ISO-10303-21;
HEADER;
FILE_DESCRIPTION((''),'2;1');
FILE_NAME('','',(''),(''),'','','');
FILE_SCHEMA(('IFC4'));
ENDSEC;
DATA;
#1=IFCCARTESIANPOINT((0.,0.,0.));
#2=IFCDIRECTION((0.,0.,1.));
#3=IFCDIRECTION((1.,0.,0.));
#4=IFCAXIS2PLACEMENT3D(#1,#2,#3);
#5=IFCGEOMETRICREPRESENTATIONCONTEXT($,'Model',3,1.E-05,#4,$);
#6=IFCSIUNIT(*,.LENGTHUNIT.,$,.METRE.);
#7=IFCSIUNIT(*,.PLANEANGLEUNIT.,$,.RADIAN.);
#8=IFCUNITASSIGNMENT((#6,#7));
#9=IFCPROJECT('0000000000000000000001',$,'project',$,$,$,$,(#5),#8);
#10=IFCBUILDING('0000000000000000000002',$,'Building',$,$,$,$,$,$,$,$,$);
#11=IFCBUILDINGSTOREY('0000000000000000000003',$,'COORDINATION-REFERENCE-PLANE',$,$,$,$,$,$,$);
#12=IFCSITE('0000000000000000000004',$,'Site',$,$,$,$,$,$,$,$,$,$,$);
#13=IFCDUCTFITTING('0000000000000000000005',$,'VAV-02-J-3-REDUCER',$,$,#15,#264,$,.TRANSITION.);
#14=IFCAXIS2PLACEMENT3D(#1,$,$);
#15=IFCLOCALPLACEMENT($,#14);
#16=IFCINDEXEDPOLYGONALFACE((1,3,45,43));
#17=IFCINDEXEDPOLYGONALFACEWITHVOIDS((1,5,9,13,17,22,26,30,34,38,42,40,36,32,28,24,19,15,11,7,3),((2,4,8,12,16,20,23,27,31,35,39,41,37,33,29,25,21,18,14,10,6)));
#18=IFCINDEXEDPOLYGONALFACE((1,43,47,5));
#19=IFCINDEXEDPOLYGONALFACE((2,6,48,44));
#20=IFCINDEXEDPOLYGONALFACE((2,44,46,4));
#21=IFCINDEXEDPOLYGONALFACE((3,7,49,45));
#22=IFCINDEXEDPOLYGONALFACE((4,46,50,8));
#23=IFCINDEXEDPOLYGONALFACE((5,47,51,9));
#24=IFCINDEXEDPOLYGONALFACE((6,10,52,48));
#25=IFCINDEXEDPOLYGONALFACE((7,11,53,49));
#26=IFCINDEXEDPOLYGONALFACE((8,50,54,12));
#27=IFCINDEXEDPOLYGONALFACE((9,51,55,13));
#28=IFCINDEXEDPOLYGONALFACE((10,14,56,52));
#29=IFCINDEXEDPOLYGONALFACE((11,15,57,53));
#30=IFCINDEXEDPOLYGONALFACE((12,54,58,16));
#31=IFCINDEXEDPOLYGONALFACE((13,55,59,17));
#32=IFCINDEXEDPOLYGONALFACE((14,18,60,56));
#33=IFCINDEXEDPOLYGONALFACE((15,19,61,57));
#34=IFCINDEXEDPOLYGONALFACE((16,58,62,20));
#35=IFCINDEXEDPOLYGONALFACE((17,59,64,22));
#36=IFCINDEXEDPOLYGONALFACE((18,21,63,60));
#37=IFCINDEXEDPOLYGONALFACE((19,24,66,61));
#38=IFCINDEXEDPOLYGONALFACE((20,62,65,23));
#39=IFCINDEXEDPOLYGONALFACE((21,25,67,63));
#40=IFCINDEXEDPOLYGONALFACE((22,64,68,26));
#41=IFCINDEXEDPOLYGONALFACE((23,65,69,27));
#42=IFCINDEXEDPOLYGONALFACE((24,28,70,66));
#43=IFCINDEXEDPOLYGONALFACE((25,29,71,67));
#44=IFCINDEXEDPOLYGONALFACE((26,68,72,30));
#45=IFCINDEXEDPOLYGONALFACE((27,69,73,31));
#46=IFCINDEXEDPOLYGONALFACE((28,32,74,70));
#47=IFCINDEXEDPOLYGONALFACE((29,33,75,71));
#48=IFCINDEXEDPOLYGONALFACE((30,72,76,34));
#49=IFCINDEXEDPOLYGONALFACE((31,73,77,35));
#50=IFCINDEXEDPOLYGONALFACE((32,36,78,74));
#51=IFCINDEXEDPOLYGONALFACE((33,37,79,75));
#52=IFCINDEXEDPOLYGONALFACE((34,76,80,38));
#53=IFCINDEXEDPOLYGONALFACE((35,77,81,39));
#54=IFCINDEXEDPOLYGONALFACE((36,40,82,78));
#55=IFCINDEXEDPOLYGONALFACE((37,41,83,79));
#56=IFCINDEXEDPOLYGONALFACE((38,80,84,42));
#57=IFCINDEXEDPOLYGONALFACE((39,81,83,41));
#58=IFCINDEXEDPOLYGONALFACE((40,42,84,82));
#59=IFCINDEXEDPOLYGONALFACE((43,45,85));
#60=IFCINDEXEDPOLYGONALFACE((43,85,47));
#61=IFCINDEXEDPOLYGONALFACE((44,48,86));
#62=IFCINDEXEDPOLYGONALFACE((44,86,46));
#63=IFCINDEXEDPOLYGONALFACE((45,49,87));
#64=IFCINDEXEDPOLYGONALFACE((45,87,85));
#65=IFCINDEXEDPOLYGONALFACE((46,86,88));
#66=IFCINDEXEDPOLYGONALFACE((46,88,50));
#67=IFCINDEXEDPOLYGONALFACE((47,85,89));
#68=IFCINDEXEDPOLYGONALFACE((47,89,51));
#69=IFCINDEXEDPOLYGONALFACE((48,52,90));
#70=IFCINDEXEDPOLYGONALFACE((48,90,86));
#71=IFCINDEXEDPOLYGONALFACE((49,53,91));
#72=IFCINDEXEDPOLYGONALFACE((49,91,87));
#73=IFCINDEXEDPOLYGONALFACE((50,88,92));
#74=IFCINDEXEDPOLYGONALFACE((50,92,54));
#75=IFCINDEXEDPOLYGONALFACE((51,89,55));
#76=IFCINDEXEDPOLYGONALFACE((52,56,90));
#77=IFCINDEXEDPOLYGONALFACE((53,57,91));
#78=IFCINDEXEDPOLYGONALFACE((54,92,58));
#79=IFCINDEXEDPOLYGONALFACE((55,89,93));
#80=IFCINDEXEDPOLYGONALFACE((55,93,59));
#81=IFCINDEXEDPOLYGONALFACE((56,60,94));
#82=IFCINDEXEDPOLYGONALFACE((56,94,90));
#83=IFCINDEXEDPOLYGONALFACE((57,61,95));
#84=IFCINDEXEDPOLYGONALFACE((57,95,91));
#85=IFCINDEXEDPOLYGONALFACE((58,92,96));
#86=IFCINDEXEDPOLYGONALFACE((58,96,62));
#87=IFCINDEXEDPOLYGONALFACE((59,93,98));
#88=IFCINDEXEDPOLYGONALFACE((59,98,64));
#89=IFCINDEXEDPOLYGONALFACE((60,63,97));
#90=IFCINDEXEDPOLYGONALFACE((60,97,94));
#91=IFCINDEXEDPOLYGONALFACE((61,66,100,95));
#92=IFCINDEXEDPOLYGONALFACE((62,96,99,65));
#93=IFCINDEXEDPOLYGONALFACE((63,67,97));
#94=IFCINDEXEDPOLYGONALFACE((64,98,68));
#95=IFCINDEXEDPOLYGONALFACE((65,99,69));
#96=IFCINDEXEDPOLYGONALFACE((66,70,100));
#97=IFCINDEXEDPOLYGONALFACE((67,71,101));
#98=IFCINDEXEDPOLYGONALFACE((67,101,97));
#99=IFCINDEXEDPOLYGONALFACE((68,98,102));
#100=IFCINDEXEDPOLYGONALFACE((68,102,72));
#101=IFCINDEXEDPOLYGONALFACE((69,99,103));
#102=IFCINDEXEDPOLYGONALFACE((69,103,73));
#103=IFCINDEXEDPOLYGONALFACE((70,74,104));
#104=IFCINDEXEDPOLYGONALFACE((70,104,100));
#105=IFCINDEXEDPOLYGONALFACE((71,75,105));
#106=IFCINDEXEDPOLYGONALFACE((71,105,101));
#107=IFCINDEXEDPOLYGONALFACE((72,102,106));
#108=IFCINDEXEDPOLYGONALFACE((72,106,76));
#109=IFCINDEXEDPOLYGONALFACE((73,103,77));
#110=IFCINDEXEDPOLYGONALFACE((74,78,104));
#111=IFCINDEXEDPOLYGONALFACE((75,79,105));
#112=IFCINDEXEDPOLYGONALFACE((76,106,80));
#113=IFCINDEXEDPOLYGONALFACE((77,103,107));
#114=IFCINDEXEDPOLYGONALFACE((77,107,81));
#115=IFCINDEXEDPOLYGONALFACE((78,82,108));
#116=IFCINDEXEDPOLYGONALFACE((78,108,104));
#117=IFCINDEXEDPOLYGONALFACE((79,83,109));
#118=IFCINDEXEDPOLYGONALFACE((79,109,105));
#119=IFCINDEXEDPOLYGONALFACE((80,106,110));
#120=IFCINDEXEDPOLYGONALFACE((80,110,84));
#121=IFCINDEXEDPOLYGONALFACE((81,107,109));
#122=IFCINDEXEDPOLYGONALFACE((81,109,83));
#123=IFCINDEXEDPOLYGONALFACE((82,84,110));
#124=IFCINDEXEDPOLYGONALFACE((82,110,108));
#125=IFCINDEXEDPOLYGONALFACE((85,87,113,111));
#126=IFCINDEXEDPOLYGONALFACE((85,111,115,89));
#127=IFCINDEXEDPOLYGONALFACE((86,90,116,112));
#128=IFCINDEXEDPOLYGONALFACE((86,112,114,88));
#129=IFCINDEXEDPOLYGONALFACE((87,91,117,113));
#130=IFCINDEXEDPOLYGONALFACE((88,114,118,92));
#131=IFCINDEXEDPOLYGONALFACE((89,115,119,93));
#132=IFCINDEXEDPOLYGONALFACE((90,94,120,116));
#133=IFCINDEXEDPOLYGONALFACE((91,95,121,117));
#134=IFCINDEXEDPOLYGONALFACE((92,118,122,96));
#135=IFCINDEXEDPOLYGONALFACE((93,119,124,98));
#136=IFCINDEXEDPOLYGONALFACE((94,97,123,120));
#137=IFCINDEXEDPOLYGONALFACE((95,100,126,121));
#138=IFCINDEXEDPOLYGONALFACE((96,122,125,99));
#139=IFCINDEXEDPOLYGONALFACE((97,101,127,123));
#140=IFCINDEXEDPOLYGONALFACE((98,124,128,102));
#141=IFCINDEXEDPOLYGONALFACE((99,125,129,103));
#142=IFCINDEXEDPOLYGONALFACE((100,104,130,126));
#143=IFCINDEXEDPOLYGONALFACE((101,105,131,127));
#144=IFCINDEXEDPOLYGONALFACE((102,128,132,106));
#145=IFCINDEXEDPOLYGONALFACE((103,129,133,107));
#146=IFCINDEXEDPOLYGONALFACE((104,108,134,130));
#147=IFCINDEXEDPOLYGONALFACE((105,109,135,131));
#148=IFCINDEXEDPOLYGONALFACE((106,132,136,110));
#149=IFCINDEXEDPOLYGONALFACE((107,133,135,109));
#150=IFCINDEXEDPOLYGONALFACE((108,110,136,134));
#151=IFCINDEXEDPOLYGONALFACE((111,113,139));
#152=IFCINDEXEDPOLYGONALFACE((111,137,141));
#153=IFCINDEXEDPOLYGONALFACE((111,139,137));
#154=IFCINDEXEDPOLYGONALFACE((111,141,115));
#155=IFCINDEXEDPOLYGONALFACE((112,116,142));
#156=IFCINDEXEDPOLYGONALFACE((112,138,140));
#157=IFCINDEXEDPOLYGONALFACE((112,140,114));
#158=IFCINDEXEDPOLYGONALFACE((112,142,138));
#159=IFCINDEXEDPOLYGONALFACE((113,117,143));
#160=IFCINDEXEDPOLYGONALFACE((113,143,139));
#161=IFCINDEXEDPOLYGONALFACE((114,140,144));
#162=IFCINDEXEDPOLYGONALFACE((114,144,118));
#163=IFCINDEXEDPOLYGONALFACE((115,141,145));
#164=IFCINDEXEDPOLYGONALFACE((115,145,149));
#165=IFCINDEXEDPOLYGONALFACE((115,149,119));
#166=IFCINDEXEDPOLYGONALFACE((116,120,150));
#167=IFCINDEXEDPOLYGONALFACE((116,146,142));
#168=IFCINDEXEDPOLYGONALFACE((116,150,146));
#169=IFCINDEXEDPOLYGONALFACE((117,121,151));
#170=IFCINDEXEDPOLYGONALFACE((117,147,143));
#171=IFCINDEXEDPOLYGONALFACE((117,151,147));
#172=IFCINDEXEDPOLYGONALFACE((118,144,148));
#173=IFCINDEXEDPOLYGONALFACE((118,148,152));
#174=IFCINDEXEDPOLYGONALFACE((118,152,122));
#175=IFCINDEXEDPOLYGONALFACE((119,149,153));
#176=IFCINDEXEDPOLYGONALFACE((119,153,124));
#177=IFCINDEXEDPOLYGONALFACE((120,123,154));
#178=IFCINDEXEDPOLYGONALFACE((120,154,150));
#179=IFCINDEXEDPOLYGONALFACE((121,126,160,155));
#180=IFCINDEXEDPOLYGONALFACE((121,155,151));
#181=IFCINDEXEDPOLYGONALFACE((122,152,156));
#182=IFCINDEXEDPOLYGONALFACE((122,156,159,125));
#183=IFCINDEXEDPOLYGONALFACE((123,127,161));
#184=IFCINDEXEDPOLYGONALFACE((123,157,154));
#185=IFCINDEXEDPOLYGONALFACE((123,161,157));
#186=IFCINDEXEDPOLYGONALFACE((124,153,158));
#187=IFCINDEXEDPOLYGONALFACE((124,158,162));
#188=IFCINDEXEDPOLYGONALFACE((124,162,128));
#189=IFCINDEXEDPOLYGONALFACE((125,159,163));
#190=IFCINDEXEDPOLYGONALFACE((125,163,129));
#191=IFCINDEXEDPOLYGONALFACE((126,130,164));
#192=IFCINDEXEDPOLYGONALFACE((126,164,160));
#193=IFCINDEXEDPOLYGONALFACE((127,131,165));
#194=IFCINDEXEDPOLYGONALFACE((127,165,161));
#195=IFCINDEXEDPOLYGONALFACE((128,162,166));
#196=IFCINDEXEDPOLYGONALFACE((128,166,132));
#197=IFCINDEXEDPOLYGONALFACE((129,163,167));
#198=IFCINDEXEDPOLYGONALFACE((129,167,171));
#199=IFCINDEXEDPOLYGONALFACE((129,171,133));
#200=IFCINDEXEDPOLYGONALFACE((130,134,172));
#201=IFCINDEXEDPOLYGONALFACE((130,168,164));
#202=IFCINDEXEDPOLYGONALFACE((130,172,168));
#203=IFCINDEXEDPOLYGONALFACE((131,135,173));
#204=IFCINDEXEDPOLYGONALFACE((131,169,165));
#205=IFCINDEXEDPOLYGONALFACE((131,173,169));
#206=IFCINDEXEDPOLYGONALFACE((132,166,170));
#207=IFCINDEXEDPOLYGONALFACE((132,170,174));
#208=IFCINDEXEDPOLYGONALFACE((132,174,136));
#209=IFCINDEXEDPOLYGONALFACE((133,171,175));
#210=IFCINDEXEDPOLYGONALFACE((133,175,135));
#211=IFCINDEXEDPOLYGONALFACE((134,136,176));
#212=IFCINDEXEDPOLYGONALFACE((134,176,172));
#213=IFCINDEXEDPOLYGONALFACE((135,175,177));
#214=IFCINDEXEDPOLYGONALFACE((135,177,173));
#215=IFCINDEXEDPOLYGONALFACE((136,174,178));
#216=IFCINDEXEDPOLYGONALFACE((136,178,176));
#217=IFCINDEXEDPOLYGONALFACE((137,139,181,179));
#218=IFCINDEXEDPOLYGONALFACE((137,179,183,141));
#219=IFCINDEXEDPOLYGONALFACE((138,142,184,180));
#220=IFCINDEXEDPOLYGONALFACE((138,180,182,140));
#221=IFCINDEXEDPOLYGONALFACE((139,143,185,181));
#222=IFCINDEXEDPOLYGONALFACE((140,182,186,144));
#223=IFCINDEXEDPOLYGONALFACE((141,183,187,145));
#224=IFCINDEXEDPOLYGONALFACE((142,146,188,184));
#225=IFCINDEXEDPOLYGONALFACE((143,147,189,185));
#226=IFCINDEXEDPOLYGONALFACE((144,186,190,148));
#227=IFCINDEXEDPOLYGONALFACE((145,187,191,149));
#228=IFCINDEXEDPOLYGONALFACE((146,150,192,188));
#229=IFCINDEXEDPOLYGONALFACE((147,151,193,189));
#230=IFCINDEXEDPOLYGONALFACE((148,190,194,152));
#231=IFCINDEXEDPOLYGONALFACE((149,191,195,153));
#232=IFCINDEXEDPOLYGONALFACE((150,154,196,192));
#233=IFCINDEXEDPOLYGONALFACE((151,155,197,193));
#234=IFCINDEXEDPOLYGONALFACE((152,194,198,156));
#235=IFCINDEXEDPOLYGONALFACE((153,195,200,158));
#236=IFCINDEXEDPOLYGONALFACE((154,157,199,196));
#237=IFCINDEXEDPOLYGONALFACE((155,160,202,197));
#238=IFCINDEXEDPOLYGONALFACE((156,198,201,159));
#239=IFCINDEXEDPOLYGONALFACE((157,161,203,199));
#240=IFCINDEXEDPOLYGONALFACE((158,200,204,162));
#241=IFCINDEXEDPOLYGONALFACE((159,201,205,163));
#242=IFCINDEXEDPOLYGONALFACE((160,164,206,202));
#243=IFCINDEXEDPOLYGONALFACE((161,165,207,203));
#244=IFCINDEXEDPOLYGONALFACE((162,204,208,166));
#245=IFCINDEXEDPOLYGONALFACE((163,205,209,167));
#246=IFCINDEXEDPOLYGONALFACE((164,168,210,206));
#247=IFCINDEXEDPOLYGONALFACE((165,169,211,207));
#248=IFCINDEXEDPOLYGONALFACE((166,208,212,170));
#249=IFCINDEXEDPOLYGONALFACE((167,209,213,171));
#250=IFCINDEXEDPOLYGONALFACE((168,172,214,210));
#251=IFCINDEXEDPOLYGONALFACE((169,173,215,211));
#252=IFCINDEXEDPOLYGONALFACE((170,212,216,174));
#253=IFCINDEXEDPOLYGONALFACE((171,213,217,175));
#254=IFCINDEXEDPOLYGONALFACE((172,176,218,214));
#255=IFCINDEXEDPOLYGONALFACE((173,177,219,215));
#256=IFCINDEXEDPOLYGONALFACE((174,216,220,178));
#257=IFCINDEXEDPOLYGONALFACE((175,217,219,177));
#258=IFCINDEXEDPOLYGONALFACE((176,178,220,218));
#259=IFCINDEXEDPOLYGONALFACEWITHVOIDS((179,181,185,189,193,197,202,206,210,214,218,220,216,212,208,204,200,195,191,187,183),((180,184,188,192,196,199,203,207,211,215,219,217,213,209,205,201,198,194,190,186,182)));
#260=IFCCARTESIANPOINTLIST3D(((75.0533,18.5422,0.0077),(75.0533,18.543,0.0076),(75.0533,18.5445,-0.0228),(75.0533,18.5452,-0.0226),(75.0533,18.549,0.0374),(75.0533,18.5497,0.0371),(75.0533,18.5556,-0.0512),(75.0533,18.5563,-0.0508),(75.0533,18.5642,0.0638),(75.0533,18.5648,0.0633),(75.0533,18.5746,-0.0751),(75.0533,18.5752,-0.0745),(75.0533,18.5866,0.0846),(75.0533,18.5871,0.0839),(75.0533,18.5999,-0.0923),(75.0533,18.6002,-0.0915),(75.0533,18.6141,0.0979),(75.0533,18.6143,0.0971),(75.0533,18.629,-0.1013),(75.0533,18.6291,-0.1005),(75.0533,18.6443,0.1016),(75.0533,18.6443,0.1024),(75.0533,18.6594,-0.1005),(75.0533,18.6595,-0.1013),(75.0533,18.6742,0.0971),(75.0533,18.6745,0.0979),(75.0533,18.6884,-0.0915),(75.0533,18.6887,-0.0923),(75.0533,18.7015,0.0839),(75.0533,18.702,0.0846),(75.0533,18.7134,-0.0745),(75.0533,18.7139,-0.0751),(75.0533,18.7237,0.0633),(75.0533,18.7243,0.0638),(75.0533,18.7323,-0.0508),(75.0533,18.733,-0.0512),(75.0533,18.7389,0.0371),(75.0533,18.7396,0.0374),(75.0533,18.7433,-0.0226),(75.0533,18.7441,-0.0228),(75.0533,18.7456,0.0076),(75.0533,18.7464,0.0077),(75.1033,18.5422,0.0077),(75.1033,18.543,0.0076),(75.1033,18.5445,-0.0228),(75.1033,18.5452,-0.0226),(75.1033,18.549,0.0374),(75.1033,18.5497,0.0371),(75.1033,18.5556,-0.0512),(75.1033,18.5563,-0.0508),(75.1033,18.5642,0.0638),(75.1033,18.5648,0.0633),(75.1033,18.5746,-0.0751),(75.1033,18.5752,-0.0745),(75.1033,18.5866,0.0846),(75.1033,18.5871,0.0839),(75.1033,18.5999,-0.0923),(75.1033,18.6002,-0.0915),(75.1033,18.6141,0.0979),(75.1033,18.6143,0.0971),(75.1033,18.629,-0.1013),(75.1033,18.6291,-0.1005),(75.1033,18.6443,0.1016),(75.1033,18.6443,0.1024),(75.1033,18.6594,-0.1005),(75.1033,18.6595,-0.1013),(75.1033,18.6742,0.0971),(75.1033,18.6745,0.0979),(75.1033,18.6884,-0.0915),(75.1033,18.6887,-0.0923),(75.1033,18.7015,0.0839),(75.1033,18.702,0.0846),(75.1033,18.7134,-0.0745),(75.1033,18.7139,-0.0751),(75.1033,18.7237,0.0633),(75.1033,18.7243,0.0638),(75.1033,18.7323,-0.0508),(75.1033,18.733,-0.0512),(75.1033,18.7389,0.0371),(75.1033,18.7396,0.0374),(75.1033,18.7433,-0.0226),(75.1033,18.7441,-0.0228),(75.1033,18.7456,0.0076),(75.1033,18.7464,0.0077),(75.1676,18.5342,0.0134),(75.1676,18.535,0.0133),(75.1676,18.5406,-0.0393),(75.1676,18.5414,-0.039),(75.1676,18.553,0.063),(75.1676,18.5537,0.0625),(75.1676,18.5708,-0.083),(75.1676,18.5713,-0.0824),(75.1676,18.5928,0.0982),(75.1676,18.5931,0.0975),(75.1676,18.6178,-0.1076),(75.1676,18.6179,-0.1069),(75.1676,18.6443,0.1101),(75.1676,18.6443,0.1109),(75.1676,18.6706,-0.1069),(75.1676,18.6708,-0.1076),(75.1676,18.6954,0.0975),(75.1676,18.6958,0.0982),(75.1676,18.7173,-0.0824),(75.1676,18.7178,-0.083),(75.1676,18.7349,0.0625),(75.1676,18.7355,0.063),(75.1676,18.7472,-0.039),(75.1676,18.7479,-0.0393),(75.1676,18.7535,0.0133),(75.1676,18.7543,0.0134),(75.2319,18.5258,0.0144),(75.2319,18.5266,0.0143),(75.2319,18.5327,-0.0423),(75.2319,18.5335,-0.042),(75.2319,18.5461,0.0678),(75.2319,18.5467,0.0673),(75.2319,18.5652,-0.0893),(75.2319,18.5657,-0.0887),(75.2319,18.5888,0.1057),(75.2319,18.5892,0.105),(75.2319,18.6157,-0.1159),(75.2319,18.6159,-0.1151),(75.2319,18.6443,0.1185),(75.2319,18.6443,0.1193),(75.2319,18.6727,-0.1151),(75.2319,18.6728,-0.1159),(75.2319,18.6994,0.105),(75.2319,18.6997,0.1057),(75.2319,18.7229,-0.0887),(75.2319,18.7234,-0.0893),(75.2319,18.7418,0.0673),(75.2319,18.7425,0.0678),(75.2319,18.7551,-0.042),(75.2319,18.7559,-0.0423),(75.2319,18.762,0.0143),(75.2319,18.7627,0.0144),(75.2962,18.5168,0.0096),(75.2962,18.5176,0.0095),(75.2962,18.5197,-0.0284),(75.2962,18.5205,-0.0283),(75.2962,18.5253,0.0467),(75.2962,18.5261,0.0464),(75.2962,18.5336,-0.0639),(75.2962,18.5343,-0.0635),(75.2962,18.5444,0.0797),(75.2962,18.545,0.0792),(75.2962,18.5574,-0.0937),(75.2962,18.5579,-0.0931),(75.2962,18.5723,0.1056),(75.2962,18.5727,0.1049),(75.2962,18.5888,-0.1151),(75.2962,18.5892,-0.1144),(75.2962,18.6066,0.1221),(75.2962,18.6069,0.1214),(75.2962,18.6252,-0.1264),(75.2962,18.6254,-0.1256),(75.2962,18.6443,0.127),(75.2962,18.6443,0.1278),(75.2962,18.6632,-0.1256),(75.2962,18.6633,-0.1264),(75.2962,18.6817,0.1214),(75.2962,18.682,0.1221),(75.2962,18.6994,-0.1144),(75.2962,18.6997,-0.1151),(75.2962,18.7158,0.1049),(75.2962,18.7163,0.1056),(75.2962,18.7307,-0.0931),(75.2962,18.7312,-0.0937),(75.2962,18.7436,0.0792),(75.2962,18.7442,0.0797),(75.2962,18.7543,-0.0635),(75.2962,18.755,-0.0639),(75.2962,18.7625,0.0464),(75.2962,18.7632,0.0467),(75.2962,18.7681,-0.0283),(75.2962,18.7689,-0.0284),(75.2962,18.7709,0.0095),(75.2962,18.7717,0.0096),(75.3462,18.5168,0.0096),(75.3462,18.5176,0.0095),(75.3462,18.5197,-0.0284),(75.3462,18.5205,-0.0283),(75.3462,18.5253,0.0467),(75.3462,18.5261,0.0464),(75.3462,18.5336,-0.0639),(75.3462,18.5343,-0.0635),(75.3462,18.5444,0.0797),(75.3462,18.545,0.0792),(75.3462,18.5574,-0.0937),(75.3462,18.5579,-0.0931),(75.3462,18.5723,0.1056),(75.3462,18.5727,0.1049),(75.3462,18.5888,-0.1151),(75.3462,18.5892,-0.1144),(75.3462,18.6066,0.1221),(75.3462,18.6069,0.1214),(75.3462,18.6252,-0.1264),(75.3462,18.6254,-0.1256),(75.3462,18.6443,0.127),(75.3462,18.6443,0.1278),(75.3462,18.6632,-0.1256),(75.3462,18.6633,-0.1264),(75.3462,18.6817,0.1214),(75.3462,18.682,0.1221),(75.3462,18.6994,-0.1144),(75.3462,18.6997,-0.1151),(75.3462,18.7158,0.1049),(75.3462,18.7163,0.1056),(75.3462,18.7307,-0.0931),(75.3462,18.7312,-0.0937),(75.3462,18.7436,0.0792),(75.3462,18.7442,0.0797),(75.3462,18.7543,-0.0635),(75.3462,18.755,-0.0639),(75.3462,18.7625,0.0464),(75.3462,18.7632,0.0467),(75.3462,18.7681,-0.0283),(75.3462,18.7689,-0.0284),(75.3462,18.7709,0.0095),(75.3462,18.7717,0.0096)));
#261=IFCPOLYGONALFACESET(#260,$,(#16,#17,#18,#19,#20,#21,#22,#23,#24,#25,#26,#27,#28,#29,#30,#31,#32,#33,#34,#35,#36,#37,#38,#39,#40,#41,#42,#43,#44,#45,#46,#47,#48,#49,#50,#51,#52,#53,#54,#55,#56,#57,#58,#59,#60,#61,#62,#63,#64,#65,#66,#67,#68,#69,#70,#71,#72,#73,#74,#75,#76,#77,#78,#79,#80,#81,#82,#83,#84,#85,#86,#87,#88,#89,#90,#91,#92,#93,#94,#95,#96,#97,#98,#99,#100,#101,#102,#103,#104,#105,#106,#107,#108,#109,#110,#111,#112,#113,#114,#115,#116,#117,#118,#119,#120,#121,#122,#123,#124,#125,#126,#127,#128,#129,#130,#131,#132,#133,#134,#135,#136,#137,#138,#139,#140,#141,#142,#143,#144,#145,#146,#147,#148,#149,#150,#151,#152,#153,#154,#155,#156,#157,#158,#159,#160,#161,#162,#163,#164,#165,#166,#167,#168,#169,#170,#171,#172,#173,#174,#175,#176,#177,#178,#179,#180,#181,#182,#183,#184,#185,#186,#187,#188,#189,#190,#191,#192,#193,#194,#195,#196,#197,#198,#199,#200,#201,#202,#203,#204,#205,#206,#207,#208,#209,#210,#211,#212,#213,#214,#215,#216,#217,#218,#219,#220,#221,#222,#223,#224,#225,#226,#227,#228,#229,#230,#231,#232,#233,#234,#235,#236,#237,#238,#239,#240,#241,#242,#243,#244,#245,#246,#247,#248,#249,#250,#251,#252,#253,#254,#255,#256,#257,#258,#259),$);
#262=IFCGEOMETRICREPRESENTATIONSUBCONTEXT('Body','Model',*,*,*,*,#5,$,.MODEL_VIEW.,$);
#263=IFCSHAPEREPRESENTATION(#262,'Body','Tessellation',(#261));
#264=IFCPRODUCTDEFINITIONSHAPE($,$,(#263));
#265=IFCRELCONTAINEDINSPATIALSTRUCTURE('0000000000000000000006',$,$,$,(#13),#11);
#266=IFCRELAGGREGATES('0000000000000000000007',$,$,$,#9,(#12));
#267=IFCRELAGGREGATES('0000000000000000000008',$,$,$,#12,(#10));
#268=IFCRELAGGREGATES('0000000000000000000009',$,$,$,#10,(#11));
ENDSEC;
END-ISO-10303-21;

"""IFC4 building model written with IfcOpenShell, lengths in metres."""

from ifc_helpers import new_model, entity, si_unit, frame, origin_with_axes, place, context, subcontext, project, spatial, element, save


model = new_model("IFC4")

# Units and contexts
model_context_1 = context("Model", 3, precision=1e-05, world=origin_with_axes())
body_context_1 = subcontext(model_context_1, "Body", "Model", "MODEL_VIEW")
ifc_project = project(units=[si_unit("LENGTHUNIT", "METRE"), si_unit("PLANEANGLEUNIT", "RADIAN")], contexts=[model_context_1])

# Site, building, storey
site = spatial("IfcSite", under=ifc_project, Name="Site")
building = spatial("IfcBuilding", under=site, Name="Building")
storey = spatial("IfcBuildingStorey", under=building, Name="COORDINATION-REFERENCE-PLANE")

# Duct fitting
for number, where, z_axis, x_axis, name in (
    (1, (75.3462, 18.6443, 0.0), (0.0, -1.0, 0.0), (0.0, 0.0, 1.0), "VAV-02-J-3-REDUCER"),
):
    element("IfcDuctFitting", number, at=place(None, frame(where, z_axis=z_axis, x_axis=x_axis)), inside=storey, Name=name, PredefinedType="TRANSITION", context=body_context_1, shape_type="SweptSolid", body=[
        entity("IfcRevolvedAreaSolid", entity("IfcArbitraryClosedProfileDef", "AREA", None, entity("IfcPolyline", [entity("IfcCartesianPoint", [0.1278, 0.0]), entity("IfcCartesianPoint", [0.1278, 0.05]), entity("IfcCartesianPoint", [0.1024, 0.2429]), entity("IfcCartesianPoint", [0.1024, 0.2929]), entity("IfcCartesianPoint", [0.1016, 0.2929]), entity("IfcCartesianPoint", [0.1016, 0.2429]), entity("IfcCartesianPoint", [0.127, 0.05]), entity("IfcCartesianPoint", [0.127, 0.0]), entity("IfcCartesianPoint", [0.1278, 0.0])])), entity("IfcAxis2Placement3D", entity("IfcCartesianPoint", [0.0, 0.0, 0.0])), entity("IfcAxis1Placement", entity("IfcCartesianPoint", [0.0, 0.0, 0.0]), entity("IfcDirection", [0.0, 1.0, 0.0])), 6.283185),
    ])

save(model, "model.ifc")
